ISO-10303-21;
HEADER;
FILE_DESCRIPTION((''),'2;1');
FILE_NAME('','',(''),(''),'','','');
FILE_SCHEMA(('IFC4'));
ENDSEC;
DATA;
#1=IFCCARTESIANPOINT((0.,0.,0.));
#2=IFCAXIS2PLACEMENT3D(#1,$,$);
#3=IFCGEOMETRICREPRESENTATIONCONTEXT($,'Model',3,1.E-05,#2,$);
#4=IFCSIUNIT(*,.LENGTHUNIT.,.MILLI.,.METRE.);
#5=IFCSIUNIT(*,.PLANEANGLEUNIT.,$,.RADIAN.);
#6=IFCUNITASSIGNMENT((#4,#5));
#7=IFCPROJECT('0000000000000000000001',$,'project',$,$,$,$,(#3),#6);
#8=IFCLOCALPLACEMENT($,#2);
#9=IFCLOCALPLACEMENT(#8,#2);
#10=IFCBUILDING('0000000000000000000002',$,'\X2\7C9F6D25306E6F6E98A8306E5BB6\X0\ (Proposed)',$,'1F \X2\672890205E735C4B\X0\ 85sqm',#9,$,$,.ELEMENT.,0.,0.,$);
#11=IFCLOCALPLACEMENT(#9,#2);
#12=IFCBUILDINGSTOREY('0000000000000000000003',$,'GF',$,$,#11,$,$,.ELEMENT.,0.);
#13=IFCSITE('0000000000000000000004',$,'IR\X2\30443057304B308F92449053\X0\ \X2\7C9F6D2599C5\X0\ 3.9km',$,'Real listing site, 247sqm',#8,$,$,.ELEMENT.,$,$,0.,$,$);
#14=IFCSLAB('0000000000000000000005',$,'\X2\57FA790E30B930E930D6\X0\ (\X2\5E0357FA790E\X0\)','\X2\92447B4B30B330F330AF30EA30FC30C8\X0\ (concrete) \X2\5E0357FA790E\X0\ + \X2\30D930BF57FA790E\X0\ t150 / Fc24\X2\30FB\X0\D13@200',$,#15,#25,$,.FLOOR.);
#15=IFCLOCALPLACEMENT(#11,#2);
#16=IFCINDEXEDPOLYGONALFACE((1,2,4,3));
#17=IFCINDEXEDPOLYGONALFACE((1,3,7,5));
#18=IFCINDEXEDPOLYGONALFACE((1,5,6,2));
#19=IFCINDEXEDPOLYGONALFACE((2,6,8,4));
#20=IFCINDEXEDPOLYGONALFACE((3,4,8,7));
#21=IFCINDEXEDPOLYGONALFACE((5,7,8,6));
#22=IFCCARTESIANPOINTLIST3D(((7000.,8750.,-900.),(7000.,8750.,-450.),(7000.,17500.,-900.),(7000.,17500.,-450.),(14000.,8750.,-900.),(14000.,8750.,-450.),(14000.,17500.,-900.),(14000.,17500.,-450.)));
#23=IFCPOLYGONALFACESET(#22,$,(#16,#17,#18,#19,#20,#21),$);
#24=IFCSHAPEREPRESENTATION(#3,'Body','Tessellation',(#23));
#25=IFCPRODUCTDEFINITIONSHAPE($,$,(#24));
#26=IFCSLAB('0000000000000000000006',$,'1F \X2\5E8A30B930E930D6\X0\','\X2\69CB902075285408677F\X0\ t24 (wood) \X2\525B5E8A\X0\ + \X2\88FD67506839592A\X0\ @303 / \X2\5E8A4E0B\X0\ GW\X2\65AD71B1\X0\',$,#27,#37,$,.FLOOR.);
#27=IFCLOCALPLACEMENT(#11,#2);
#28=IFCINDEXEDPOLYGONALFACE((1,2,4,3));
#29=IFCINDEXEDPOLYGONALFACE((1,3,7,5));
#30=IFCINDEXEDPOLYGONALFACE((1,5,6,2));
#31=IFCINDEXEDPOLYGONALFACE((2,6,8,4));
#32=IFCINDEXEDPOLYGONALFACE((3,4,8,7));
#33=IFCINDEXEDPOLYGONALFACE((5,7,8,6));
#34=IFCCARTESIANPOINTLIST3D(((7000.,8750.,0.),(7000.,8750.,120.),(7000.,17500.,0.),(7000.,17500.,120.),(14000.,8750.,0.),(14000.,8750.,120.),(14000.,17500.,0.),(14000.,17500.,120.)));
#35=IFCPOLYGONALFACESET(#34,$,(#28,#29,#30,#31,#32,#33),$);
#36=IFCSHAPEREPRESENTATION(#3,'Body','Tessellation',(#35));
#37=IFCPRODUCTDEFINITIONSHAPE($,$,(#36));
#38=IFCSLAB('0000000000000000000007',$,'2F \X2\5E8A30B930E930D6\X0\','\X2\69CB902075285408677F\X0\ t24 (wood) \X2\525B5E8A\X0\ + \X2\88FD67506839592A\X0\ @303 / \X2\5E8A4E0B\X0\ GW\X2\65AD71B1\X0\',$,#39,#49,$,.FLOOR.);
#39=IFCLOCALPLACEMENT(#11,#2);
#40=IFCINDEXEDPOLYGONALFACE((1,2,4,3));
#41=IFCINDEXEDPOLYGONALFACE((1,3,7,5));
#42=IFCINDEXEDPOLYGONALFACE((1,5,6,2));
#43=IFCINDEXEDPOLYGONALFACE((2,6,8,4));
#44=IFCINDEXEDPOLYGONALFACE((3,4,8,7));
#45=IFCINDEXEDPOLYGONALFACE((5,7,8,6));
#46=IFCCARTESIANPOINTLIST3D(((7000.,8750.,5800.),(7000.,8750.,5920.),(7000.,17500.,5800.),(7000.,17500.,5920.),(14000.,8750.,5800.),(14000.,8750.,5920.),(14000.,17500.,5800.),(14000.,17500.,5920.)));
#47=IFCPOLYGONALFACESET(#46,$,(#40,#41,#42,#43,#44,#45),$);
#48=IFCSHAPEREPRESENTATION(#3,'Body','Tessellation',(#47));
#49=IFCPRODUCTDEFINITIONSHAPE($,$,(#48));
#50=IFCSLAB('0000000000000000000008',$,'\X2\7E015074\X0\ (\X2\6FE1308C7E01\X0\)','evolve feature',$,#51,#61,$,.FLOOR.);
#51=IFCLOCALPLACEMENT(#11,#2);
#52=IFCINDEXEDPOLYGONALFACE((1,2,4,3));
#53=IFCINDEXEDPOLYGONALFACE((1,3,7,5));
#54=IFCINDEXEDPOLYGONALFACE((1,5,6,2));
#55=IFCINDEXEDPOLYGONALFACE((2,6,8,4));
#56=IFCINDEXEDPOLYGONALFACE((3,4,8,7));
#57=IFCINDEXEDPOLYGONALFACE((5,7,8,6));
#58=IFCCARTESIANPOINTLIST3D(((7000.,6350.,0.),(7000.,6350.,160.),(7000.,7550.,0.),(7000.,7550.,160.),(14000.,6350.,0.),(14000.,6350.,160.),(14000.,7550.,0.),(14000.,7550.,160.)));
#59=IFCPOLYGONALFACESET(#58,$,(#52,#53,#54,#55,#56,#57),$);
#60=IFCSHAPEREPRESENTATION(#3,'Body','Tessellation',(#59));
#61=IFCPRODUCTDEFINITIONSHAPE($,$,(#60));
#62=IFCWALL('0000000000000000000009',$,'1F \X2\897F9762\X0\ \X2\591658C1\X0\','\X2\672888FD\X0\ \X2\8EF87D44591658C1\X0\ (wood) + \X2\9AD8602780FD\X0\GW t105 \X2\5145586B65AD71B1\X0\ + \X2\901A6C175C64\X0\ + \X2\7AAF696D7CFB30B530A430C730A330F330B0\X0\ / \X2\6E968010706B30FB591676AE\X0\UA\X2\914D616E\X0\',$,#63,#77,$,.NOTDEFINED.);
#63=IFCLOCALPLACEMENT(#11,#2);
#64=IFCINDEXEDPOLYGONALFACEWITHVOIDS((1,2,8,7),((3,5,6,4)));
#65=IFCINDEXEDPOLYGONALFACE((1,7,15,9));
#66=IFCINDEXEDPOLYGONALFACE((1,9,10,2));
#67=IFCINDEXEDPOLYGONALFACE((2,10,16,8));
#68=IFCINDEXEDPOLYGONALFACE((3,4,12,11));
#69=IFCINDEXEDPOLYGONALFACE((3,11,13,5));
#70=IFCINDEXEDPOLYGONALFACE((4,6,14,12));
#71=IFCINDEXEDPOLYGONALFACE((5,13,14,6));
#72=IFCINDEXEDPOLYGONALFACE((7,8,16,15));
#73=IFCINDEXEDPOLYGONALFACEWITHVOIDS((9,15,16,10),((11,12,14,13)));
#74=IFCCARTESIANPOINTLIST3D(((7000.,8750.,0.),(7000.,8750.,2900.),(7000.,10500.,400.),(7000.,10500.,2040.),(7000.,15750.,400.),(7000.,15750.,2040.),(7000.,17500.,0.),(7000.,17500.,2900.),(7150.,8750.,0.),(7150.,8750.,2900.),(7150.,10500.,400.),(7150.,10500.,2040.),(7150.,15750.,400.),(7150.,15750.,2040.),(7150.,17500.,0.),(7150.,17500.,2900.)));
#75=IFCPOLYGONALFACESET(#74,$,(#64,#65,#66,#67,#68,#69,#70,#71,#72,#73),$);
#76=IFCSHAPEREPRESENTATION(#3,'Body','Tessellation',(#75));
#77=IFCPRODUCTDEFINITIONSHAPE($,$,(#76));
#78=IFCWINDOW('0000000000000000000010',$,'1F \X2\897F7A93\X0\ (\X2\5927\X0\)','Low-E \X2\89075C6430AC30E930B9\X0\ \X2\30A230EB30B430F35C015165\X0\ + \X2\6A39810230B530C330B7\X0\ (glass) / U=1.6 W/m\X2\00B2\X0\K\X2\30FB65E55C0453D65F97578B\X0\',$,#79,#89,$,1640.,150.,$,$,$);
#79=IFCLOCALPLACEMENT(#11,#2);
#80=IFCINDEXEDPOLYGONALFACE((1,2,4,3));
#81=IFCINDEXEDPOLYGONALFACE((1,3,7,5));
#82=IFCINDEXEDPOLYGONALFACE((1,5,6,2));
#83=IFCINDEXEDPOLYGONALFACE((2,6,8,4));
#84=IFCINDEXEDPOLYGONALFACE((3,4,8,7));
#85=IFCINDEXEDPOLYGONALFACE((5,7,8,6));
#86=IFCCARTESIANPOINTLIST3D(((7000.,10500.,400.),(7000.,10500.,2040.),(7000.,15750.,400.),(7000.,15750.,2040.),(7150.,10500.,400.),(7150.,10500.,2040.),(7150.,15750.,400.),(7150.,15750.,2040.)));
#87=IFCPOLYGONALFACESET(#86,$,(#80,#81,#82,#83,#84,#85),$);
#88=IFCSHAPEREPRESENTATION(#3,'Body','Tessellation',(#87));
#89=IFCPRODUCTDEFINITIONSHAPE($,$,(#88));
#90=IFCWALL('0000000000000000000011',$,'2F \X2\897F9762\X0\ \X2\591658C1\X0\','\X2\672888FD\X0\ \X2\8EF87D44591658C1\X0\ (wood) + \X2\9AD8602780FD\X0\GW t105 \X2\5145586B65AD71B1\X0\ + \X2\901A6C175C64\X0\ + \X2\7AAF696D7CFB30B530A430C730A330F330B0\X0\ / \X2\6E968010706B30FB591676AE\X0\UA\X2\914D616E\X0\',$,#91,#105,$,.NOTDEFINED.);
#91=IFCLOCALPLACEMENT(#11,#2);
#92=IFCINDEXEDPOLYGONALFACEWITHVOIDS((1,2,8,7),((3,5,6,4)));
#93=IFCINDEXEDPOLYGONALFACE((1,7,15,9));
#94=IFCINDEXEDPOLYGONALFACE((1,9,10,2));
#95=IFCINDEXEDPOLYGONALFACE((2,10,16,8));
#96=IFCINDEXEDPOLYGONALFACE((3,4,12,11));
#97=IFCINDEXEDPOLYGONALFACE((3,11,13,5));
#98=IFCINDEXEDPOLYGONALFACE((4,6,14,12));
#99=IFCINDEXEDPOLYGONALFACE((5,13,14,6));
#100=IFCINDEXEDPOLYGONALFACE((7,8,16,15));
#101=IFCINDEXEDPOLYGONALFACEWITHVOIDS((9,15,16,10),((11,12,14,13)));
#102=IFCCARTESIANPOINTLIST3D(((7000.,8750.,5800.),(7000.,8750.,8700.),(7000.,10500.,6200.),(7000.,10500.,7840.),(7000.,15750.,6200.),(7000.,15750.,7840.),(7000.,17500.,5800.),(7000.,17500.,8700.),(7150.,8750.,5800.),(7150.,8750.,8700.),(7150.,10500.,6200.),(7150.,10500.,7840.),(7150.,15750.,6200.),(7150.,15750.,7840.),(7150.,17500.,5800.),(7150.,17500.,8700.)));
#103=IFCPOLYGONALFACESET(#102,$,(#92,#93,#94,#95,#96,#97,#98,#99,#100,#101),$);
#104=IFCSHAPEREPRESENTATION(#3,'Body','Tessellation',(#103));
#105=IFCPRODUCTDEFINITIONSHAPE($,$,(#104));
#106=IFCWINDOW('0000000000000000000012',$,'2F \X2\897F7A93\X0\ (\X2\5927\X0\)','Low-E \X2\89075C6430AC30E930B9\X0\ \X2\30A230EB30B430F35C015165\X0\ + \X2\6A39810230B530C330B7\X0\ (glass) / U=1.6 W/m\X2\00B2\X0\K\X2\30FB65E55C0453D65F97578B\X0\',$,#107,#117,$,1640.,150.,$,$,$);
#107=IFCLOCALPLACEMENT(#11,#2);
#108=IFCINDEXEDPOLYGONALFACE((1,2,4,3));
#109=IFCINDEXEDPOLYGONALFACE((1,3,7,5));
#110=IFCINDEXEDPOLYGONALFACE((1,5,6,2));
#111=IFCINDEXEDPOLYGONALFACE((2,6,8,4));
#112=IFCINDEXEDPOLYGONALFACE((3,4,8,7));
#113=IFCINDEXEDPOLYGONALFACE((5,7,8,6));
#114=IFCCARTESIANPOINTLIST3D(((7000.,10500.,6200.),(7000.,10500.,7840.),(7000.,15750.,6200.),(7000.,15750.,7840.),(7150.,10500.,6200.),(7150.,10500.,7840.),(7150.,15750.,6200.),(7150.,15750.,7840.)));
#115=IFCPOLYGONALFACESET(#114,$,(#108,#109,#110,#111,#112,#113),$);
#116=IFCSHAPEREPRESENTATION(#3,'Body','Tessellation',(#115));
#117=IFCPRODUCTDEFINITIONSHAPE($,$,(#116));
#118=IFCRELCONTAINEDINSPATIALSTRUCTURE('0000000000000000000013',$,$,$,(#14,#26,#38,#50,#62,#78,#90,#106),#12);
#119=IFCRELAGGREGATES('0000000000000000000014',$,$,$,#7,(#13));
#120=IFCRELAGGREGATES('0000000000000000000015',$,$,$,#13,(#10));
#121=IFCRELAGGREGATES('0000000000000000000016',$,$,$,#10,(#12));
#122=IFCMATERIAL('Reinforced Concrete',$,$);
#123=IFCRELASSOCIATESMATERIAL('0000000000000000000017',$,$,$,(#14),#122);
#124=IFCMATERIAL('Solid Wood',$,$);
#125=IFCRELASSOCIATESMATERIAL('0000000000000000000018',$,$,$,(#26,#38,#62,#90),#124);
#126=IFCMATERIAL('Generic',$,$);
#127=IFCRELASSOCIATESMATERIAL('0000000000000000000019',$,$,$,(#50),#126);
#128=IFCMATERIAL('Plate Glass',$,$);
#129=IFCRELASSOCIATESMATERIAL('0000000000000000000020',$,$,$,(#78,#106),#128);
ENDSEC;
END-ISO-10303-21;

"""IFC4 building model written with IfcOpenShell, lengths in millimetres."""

from ifc_helpers import new_model, si_unit, frame, frame_2d, origin, place, context, project, spatial, rectangle, extrude, material, element, fill, save


model = new_model("IFC4")

# Units and contexts
model_context = context("Model", 3, precision=1e-05, world=origin())
ifc_project = project(units=[si_unit("LENGTHUNIT", "METRE", prefix="MILLI"), si_unit("PLANEANGLEUNIT", "RADIAN")], contexts=[model_context])

# Site, building, storey
site_placement = place(None, origin())
site = spatial("IfcSite", under=ifc_project, at=site_placement, Name="IRいしかわ鉄道 粟津駅 3.9km", ObjectType="Real listing site, 247sqm", CompositionType="ELEMENT", RefElevation=0.0)
building_placement = place(site_placement, origin())
building = spatial("IfcBuilding", under=site, at=building_placement, Name="粟津の潮風の家 (Proposed)", ObjectType="1F 木造平屋 85sqm", CompositionType="ELEMENT", ElevationOfRefHeight=0.0, ElevationOfTerrain=0.0)
storey_placement = place(building_placement, origin())
storey = spatial("IfcBuildingStorey", under=building, at=storey_placement, Name="GF", CompositionType="ELEMENT", Elevation=0.0)

# Slabs
ifc_material_1 = material(Name="Reinforced Concrete")
slab_1_placement = place(storey_placement, frame((3500.0, 4375.0, -450.0)))
element("IfcSlab", 1, at=slab_1_placement, inside=storey, material=ifc_material_1, Name="基礎スラブ (布基礎)", Description="鉄筋コンクリート (concrete) 布基礎 + ベタ基礎 t150 / Fc24・D13@200", PredefinedType="FLOOR", context=model_context, shape_type="SweptSolid", body=[
    extrude(rectangle(XDim=7000.0, YDim=8750.0, at=frame_2d((3500.0, 4375.0))), frame((3500.0, 4375.0, -450.0)), (0.0, 0.0, 1.0), 450.0),
])
ifc_material_2 = material(Name="Solid Wood")
slab_2_placement = place(storey_placement, frame((3500.0, 4375.0, 0.0)))
element("IfcSlab", 2, at=slab_2_placement, inside=storey, material=ifc_material_2, Name="1F 床スラブ", Description="構造用合板 t24 (wood) 剛床 + 製材根太 @303 / 床下 GW断熱", PredefinedType="FLOOR", context=model_context, shape_type="SweptSolid", body=[
    extrude(rectangle(XDim=7000.0, YDim=8750.0, at=frame_2d((3500.0, 4375.0))), frame((3500.0, 4375.0, 0.0)), (0.0, 0.0, 1.0), 120.0),
])
slab_3_placement = place(storey_placement, frame((3500.0, 4375.0, 2900.0)))
element("IfcSlab", 3, at=slab_3_placement, inside=storey, material=ifc_material_2, Name="2F 床スラブ", Description="構造用合板 t24 (wood) 剛床 + 製材根太 @303 / 床下 GW断熱", PredefinedType="FLOOR", context=model_context, shape_type="SweptSolid", body=[
    extrude(rectangle(XDim=7000.0, YDim=8750.0, at=frame_2d((3500.0, 4375.0))), frame((3500.0, 4375.0, 2900.0)), (0.0, 0.0, 1.0), 120.0),
])
ifc_material_3 = material(Name="Generic")
slab_4_placement = place(storey_placement, frame((3500.0, 3175.0, 0.0)))
element("IfcSlab", 4, at=slab_4_placement, inside=storey, material=ifc_material_3, Name="縁側 (濡れ縁)", Description="evolve feature", PredefinedType="FLOOR", context=model_context, shape_type="SweptSolid", body=[
    extrude(rectangle(XDim=7000.0, YDim=1200.0, at=frame_2d((3500.0, 600.0))), frame((3500.0, 3175.0, 0.0)), (0.0, 0.0, 1.0), 160.0),
])

# Shared definitions
ifc_material_4 = material(Name="Plate Glass")

# Wall, opening, window
wall_1_placement = place(storey_placement, frame((3500.0, 4375.0, 0.0)))
wall_1 = element("IfcWall", 5, at=wall_1_placement, inside=storey, material=ifc_material_2, Name="1F 西面 外壁", Description="木製 軸組外壁 (wood) + 高性能GW t105 充填断熱 + 通気層 + 窯業系サイディング / 準耐火・外皮UA配慮", PredefinedType="NOTDEFINED", context=model_context, shape_type="SweptSolid", body=[
    extrude(rectangle(XDim=150.0, YDim=8750.0, at=frame_2d((75.0, 4375.0))), frame((3500.0, 4375.0, 0.0)), (0.0, 0.0, 1.0), 2900.0),
])
opening_1_placement = place(storey_placement, frame((3500.0, 5250.0, 200.0)))
opening_1 = element("IfcOpeningElement", 6, at=opening_1_placement, cuts=wall_1, PredefinedType="NOTDEFINED", context=model_context, shape_type="SweptSolid", body=[
    extrude(rectangle(XDim=150.0, YDim=5250.0, at=frame_2d((75.0, 2625.0))), frame((3500.0, 5250.0, 200.0)), (0.0, 0.0, 1.0), 1640.0),
])
window_1_placement = place(storey_placement, frame((3500.0, 5250.0, 200.0)))
window_1 = element("IfcWindow", 7, at=window_1_placement, inside=storey, material=ifc_material_4, Name="1F 西窓 (大)", Description="Low-E 複層ガラス アルゴン封入 + 樹脂サッシ (glass) / U=1.6 W/m²K・日射取得型", OverallHeight=1640.0, OverallWidth=150.0, context=model_context, shape_type="SweptSolid", body=[
    extrude(rectangle(XDim=150.0, YDim=5250.0, at=frame_2d((75.0, 2625.0))), frame((3500.0, 5250.0, 200.0)), (0.0, 0.0, 1.0), 1640.0),
])
fill(opening_1, window_1)

# Wall, opening, window
wall_2_placement = place(storey_placement, frame((3500.0, 4375.0, 2900.0)))
wall_2 = element("IfcWall", 8, at=wall_2_placement, inside=storey, material=ifc_material_2, Name="2F 西面 外壁", Description="木製 軸組外壁 (wood) + 高性能GW t105 充填断熱 + 通気層 + 窯業系サイディング / 準耐火・外皮UA配慮", PredefinedType="NOTDEFINED", context=model_context, shape_type="SweptSolid", body=[
    extrude(rectangle(XDim=150.0, YDim=8750.0, at=frame_2d((75.0, 4375.0))), frame((3500.0, 4375.0, 2900.0)), (0.0, 0.0, 1.0), 2900.0),
])
opening_2_placement = place(storey_placement, frame((3500.0, 5250.0, 3100.0)))
opening_2 = element("IfcOpeningElement", 9, at=opening_2_placement, cuts=wall_2, PredefinedType="NOTDEFINED", context=model_context, shape_type="SweptSolid", body=[
    extrude(rectangle(XDim=150.0, YDim=5250.0, at=frame_2d((75.0, 2625.0))), frame((3500.0, 5250.0, 3100.0)), (0.0, 0.0, 1.0), 1640.0),
])
window_2_placement = place(storey_placement, frame((3500.0, 5250.0, 3100.0)))
window_2 = element("IfcWindow", 10, at=window_2_placement, inside=storey, material=ifc_material_4, Name="2F 西窓 (大)", Description="Low-E 複層ガラス アルゴン封入 + 樹脂サッシ (glass) / U=1.6 W/m²K・日射取得型", OverallHeight=1640.0, OverallWidth=150.0, context=model_context, shape_type="SweptSolid", body=[
    extrude(rectangle(XDim=150.0, YDim=5250.0, at=frame_2d((75.0, 2625.0))), frame((3500.0, 5250.0, 3100.0)), (0.0, 0.0, 1.0), 1640.0),
])
fill(opening_2, window_2)

save(model, "model.ifc")
